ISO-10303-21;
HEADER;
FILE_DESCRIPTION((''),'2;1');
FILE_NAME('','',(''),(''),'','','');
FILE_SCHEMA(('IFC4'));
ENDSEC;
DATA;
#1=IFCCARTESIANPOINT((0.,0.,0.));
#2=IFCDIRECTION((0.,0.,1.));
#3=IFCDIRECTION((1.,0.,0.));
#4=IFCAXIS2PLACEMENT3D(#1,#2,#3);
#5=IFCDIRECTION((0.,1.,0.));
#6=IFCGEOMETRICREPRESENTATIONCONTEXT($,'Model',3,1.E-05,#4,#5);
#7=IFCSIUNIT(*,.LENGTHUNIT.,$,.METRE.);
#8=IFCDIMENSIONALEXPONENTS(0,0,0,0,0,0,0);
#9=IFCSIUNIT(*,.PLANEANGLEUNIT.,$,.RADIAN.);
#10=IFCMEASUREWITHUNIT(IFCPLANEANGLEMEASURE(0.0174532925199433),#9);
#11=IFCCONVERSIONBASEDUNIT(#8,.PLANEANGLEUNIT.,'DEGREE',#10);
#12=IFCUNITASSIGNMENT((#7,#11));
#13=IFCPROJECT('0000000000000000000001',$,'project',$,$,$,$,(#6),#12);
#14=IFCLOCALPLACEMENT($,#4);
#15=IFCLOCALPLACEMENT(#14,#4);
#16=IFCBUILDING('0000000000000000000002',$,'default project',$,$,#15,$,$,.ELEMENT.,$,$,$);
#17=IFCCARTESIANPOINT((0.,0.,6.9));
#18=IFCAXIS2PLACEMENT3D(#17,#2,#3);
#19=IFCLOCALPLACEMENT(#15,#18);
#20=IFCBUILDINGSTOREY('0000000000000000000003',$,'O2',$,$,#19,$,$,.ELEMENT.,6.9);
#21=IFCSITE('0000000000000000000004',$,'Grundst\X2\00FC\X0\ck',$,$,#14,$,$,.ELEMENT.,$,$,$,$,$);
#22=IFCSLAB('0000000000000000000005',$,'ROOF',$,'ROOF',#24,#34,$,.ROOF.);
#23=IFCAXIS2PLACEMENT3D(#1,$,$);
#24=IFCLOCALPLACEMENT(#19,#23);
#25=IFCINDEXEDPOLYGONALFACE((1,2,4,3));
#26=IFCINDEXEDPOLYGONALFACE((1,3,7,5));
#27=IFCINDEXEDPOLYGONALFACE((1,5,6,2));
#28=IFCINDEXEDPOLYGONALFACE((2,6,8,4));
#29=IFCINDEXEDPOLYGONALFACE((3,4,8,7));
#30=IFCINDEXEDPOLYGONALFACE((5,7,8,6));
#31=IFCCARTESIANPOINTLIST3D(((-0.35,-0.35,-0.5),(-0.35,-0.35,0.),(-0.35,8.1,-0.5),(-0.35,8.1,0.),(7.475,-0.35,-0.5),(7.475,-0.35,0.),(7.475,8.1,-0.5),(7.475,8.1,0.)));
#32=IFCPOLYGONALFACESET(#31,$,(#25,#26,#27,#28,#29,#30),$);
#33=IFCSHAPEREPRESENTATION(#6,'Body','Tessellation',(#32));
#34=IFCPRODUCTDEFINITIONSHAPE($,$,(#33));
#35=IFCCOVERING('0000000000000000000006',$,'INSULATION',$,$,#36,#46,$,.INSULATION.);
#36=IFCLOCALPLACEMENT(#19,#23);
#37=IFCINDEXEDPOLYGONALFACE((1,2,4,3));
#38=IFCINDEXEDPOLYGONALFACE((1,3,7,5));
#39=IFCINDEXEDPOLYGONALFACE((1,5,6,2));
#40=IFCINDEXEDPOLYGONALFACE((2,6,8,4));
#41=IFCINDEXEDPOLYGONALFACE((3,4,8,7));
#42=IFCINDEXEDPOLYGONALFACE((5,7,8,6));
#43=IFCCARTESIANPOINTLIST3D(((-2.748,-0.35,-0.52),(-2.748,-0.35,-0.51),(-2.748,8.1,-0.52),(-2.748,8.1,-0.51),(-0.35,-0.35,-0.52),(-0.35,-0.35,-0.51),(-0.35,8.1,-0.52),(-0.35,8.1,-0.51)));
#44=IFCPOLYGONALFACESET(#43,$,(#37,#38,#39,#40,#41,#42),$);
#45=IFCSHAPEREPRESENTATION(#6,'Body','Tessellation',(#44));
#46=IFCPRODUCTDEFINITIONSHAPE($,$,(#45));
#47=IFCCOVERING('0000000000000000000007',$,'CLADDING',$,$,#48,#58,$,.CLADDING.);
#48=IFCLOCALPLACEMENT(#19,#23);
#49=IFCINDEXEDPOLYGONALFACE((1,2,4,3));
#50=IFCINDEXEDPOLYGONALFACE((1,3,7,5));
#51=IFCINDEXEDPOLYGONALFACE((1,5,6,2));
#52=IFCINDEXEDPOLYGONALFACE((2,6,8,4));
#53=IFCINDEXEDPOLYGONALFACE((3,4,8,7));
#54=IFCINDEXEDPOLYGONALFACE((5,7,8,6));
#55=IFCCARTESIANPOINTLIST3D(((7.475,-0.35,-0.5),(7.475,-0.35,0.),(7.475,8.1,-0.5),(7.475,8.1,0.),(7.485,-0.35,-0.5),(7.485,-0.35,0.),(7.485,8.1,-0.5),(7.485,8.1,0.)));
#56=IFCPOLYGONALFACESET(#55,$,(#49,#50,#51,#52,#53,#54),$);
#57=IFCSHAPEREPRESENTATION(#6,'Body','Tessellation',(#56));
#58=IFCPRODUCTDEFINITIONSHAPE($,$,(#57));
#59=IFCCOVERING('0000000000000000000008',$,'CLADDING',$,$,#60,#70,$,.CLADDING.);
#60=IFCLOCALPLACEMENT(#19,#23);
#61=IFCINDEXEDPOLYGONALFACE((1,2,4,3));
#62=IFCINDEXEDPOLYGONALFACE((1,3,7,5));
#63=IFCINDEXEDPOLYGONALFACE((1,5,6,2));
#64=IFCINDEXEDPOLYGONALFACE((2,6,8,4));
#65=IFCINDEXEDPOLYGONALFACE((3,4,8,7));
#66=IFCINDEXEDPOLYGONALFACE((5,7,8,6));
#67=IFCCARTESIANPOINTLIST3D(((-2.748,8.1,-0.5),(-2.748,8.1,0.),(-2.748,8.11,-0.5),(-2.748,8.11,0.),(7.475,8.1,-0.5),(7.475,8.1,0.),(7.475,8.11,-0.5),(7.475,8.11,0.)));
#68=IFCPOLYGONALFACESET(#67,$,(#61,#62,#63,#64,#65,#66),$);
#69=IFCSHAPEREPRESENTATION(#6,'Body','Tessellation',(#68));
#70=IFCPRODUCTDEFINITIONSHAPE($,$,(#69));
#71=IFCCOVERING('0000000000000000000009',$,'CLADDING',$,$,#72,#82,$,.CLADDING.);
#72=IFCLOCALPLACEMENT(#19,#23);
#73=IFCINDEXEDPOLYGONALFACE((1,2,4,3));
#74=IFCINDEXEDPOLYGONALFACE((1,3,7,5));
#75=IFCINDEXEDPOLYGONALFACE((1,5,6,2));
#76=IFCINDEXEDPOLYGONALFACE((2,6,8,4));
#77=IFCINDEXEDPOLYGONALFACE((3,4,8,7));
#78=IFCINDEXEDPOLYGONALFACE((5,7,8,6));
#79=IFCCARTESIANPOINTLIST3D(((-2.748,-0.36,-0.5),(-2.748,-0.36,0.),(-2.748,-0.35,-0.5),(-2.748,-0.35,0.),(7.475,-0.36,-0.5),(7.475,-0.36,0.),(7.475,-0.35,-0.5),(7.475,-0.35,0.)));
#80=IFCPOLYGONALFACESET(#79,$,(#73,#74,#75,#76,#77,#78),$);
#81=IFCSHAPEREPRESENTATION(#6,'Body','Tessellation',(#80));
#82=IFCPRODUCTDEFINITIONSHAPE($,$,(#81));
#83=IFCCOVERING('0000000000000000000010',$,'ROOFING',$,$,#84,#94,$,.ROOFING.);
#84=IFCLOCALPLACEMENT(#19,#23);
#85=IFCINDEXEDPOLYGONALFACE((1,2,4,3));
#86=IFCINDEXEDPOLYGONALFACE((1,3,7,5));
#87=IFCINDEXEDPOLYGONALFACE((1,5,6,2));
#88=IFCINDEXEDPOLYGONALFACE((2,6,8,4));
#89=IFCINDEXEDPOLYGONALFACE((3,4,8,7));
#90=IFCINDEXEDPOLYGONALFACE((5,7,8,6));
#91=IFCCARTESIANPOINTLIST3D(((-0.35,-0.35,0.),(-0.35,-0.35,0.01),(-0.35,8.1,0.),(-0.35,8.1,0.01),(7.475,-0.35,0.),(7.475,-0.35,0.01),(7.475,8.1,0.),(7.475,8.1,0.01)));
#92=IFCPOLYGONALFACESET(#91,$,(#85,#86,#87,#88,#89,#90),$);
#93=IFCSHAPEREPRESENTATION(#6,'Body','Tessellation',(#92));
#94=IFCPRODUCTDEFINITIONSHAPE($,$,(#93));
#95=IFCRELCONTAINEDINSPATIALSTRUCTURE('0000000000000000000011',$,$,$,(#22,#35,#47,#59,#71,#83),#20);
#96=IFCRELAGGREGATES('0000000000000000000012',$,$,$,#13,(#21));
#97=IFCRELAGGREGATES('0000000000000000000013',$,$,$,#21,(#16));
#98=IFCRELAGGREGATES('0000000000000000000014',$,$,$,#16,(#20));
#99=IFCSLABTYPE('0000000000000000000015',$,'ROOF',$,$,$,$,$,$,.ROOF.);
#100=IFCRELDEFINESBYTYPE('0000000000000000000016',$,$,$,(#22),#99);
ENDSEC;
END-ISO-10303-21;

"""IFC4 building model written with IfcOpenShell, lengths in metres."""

from ifc_helpers import new_model, entity, si_unit, converted_unit, direction, frame, origin_with_axes, place, context, project, spatial, polyline, outline, extrude, type_object, element, save


model = new_model("IFC4")

# Units and contexts
model_context = context("Model", 3, precision=1e-05, world=origin_with_axes(), true_north=direction((0.0, 1.0, 0.0)))
ifc_project = project(units=[si_unit("LENGTHUNIT", "METRE"), converted_unit("PLANEANGLEUNIT", "DEGREE", entity("IfcPlaneAngleMeasure", 0.0174532925199433), si_unit("PLANEANGLEUNIT", "RADIAN"), dimensions=[0, 0, 0, 0, 0, 0, 0])], contexts=[model_context])

# Site, building, storey
site_placement = place(None, origin_with_axes())
site = spatial("IfcSite", under=ifc_project, at=site_placement, Name="Grundstück", CompositionType="ELEMENT")
building_placement = place(site_placement, origin_with_axes())
building = spatial("IfcBuilding", under=site, at=building_placement, Name="default project", CompositionType="ELEMENT")
storey_placement = place(building_placement, frame((0.0, 0.0, 6.9), z_axis=(0.0, 0.0, 1.0), x_axis=(1.0, 0.0, 0.0)))
storey = spatial("IfcBuildingStorey", under=building, at=storey_placement, Name="O2", CompositionType="ELEMENT", Elevation=6.9)

# Slab
slab_type = type_object("IfcSlabType", Name="ROOF", PredefinedType="ROOF")
slab_placement = place(storey_placement, frame((0.0, 0.0, -0.5), z_axis=(0.0, 0.0, 1.0), x_axis=(1.0, 0.0, 0.0)))
element("IfcSlab", 1, at=slab_placement, inside=storey, type_object=slab_type, Name="ROOF", ObjectType="ROOF", PredefinedType="ROOF", context=model_context, shape_type="SweptSolid", body=[
    extrude(outline(polyline([(7.475, 8.1), (-0.35, 8.1), (-0.35, -0.35), (7.475, -0.35), (7.475, 8.1)])), origin_with_axes(), (0.0, 0.0, 1.0), 0.5),
])

# Coverings
placement = place(storey_placement, frame((0.0, 0.0, -0.5), z_axis=(0.0, 0.0, 1.0), x_axis=(1.0, 0.0, 0.0)))
covering_1_placement = place(placement, frame((0.0, 0.0, -0.01), z_axis=(0.0, 0.0, 1.0), x_axis=(1.0, 0.0, 0.0)))
element("IfcCovering", 2, at=covering_1_placement, inside=storey, Name="INSULATION", PredefinedType="INSULATION", context=model_context, shape_type="SweptSolid", body=[
    extrude(outline(polyline([(-0.35, 8.1), (-2.748, 8.1), (-2.748, -0.35), (-0.35, -0.35), (-0.35, 8.1)])), frame((0.0, 0.0, -0.01), z_axis=(0.0, 0.0, 1.0), x_axis=(1.0, 0.0, 0.0)), (0.0, 0.0, 1.0), 0.01),
])
covering_2_placement = place(slab_placement, origin_with_axes())
element("IfcCovering", 3, at=covering_2_placement, inside=storey, Name="CLADDING", PredefinedType="CLADDING", context=model_context, shape_type="SweptSolid", body=[
    extrude(outline(polyline([(7.485, -0.35), (7.485, 8.1), (7.475, 8.1), (7.475, -0.35), (7.485, -0.35)])), origin_with_axes(), (0.0, 0.0, 1.0), 0.5),
])
covering_3_placement = place(slab_placement, origin_with_axes())
element("IfcCovering", 4, at=covering_3_placement, inside=storey, Name="CLADDING", PredefinedType="CLADDING", context=model_context, shape_type="SweptSolid", body=[
    extrude(outline(polyline([(7.475, 8.11), (-2.748, 8.11), (-2.748, 8.1), (7.475, 8.1), (7.475, 8.11)])), origin_with_axes(), (0.0, 0.0, 1.0), 0.5),
])
covering_4_placement = place(slab_placement, origin_with_axes())
element("IfcCovering", 5, at=covering_4_placement, inside=storey, Name="CLADDING", PredefinedType="CLADDING", context=model_context, shape_type="SweptSolid", body=[
    extrude(outline(polyline([(-2.748, -0.36), (7.475, -0.36), (7.475, -0.35), (-2.748, -0.35), (-2.748, -0.36)])), origin_with_axes(), (0.0, 0.0, 1.0), 0.5),
])
covering_5_placement = place(slab_placement, frame((0.0, 0.0, 0.25), z_axis=(0.0, 0.0, 1.0), x_axis=(1.0, 0.0, 0.0)))
element("IfcCovering", 6, at=covering_5_placement, inside=storey, Name="ROOFING", PredefinedType="ROOFING", context=model_context, shape_type="SweptSolid", body=[
    extrude(outline(polyline([(7.475, 8.1), (-0.35, 8.1), (-0.35, -0.35), (7.475, -0.35), (7.475, 8.1)])), frame((0.0, 0.0, 0.25), z_axis=(0.0, 0.0, 1.0), x_axis=(1.0, 0.0, 0.0)), (0.0, 0.0, 1.0), 0.01),
])

save(model, "model.ifc")
